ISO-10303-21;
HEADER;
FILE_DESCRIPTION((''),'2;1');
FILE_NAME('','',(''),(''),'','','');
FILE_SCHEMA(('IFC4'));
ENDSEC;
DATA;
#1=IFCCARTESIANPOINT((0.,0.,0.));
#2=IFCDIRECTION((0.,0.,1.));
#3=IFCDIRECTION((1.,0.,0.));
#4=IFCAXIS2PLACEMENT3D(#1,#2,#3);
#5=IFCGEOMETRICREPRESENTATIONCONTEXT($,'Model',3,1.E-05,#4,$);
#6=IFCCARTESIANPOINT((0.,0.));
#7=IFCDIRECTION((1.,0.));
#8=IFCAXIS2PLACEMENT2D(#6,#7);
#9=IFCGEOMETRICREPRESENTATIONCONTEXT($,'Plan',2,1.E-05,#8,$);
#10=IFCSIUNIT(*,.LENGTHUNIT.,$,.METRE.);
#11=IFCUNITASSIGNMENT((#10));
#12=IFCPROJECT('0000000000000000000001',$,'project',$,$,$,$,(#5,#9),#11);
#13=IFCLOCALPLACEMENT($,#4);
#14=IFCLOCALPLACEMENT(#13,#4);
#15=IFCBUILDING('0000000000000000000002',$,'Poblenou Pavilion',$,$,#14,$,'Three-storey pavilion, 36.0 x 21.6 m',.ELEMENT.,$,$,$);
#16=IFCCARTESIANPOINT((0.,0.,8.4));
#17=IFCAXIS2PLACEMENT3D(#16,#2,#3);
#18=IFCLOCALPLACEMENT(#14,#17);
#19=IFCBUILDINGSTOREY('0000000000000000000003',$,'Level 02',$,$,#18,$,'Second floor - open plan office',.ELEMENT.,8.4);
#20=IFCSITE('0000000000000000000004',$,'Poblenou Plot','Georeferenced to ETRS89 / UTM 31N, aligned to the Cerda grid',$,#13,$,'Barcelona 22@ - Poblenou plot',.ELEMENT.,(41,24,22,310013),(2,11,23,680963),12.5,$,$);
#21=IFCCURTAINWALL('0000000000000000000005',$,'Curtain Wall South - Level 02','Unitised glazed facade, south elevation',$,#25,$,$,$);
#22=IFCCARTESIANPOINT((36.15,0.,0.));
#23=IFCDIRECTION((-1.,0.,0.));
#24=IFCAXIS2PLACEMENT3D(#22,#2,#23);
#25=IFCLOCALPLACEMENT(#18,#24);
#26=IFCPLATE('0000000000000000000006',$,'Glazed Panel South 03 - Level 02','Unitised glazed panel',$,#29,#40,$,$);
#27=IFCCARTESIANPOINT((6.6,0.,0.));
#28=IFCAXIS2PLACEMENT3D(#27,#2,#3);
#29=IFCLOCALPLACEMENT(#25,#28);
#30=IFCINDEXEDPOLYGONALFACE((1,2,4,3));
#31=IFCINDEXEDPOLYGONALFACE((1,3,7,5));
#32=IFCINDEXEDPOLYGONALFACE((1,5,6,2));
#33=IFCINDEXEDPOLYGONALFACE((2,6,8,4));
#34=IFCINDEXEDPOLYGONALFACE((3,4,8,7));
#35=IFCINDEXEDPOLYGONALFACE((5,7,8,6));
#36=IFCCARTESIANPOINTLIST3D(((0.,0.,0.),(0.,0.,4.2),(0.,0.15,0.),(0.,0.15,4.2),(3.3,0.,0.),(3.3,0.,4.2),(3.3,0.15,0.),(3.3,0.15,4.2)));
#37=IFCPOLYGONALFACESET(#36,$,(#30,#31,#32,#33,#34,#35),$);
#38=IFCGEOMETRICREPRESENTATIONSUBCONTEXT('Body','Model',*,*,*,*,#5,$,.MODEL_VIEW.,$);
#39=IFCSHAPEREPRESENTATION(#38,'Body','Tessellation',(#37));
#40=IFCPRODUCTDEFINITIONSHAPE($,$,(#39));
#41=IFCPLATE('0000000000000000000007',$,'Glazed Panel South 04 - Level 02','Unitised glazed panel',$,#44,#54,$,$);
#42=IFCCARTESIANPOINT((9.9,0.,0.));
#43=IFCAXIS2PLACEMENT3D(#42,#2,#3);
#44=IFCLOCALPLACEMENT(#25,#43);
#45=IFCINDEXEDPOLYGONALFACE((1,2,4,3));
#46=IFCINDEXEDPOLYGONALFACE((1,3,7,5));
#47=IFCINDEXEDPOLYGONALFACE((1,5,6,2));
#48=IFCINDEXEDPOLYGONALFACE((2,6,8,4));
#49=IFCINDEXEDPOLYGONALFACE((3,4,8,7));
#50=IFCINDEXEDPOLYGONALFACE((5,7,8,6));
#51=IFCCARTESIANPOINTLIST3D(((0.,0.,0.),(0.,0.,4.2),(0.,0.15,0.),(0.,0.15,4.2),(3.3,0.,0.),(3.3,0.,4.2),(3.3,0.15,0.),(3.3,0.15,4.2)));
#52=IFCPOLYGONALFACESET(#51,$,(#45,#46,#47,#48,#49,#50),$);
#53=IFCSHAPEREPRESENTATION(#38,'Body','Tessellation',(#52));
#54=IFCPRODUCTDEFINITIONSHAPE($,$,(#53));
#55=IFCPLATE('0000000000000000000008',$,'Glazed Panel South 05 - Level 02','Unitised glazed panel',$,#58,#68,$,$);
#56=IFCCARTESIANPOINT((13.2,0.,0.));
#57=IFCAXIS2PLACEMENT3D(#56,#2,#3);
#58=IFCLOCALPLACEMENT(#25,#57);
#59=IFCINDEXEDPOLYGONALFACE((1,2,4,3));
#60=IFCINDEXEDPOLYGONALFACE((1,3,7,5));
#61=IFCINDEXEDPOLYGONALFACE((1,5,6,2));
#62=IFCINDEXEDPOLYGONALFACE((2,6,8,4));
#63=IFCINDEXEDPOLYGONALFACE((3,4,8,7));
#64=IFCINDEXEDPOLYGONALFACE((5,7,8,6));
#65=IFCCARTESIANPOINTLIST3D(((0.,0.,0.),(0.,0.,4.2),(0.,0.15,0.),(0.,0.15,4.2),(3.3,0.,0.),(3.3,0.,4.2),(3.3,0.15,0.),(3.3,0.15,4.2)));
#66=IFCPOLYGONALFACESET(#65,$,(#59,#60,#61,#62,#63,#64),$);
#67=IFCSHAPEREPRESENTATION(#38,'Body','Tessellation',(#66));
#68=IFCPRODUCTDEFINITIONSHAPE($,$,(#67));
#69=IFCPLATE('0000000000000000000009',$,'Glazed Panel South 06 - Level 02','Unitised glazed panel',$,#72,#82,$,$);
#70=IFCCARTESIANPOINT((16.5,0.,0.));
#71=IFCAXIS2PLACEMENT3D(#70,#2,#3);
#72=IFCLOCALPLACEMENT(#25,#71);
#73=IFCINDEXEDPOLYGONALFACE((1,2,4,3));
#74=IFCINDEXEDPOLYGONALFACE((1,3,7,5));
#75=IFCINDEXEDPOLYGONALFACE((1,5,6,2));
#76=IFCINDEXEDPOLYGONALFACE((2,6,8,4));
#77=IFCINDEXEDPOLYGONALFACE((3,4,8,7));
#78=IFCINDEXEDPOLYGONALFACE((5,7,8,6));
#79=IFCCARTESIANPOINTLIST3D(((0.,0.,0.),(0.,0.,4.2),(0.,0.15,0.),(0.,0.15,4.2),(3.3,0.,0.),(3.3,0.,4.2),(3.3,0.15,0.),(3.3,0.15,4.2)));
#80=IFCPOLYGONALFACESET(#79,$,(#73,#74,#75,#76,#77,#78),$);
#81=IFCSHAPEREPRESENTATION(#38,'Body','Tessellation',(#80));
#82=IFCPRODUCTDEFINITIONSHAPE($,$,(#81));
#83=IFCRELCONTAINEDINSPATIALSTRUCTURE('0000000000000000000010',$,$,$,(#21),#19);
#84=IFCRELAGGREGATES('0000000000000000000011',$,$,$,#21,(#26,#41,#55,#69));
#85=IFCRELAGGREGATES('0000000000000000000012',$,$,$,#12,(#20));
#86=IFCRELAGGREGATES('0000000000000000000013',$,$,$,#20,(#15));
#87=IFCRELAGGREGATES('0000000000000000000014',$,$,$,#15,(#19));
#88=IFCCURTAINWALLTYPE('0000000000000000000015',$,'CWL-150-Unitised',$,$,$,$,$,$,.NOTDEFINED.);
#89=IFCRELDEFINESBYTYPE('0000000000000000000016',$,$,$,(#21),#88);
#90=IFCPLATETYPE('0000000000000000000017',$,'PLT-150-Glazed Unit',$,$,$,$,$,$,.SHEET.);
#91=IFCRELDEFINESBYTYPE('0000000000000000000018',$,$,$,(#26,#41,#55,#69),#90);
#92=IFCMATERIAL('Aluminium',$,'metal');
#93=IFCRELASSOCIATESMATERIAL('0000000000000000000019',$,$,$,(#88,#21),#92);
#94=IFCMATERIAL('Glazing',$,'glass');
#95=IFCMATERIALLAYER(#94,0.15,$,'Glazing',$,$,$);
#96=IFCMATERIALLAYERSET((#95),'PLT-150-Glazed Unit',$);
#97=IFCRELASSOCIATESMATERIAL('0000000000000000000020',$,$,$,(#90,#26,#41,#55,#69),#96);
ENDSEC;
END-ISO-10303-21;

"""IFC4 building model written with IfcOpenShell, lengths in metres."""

from ifc_helpers import new_model, si_unit, frame, origin_with_axes, origin_2d_with_axis, place, context, subcontext, project, spatial, line, indexed_curve, outline, extrude, material, layer, layer_set, layer_usage, type_object, element, aggregate, save


model = new_model("IFC4")

# Units and contexts
model_context = context("Model", 3, precision=1e-05, world=origin_with_axes())
plan_context = context("Plan", 2, precision=1e-05, world=origin_2d_with_axis())
body_context = subcontext(model_context, "Body", "Model", "MODEL_VIEW")
ifc_project = project(units=[si_unit("LENGTHUNIT", "METRE")], contexts=[model_context, plan_context])

# Site, building, storey
site_placement = place(None, origin_with_axes())
site = spatial("IfcSite", under=ifc_project, at=site_placement, Name="Poblenou Plot", Description="Georeferenced to ETRS89 / UTM 31N, aligned to the Cerda grid", LongName="Barcelona 22@ - Poblenou plot", CompositionType="ELEMENT", RefLatitude=(41, 24, 22, 310013), RefLongitude=(2, 11, 23, 680963), RefElevation=12.5)
building_placement = place(site_placement, origin_with_axes())
building = spatial("IfcBuilding", under=site, at=building_placement, Name="Poblenou Pavilion", LongName="Three-storey pavilion, 36.0 x 21.6 m", CompositionType="ELEMENT")
storey_placement = place(building_placement, frame((0.0, 0.0, 8.4), z_axis=(0.0, 0.0, 1.0), x_axis=(1.0, 0.0, 0.0)))
storey = spatial("IfcBuildingStorey", under=building, at=storey_placement, Name="Level 02", LongName="Second floor - open plan office", CompositionType="ELEMENT", Elevation=8.4)

# Curtain wall, plates
ifc_material_1 = material(Name="Aluminium", Category="metal")
curtain_wall_type = type_object("IfcCurtainWallType", Name="CWL-150-Unitised", PredefinedType="NOTDEFINED", material=ifc_material_1)
curtain_wall_1_placement = place(storey_placement, frame((36.15, 0.0, 0.0), z_axis=(0.0, 0.0, 1.0), x_axis=(-1.0, 0.0, 0.0)))
curtain_wall_1 = element("IfcCurtainWall", 1, at=curtain_wall_1_placement, inside=storey, type_object=curtain_wall_type, material=ifc_material_1, Name="Curtain Wall South - Level 02", Description="Unitised glazed facade, south elevation")
ifc_material_2 = material(Name="Glazing", Category="glass")
ifc_layer_1 = layer(ifc_material_2, 0.15, Name="Glazing")
ifc_layer_set_1 = layer_set([ifc_layer_1], Name="PLT-150-Glazed Unit")
plate_type = type_object("IfcPlateType", Name="PLT-150-Glazed Unit", PredefinedType="SHEET", material=ifc_layer_set_1)
ifc_layer_usage_1 = layer_usage(ifc_layer_set_1, "AXIS2", "POSITIVE", 0.0)
plate_1_placement = place(curtain_wall_1_placement, frame((6.6, 0.0, 0.0), z_axis=(0.0, 0.0, 1.0), x_axis=(1.0, 0.0, 0.0)))
plate_1 = element("IfcPlate", 2, at=plate_1_placement, type_object=plate_type, material=ifc_layer_usage_1, Name="Glazed Panel South 03 - Level 02", Description="Unitised glazed panel", context=body_context, shape_type="SweptSolid", body=[
    extrude(outline(indexed_curve([(0.0, 0.0), (3.3, 0.0), (3.3, 0.15), (0.0, 0.15)], segments=[line(1, 2, 3, 4, 1)])), origin_with_axes(), (0.0, 0.0, 1.0), 4.2),
])
ifc_layer_usage_2 = layer_usage(ifc_layer_set_1, "AXIS2", "POSITIVE", 0.0)
plate_2_placement = place(curtain_wall_1_placement, frame((9.9, 0.0, 0.0), z_axis=(0.0, 0.0, 1.0), x_axis=(1.0, 0.0, 0.0)))
plate_2 = element("IfcPlate", 3, at=plate_2_placement, type_object=plate_type, material=ifc_layer_usage_2, Name="Glazed Panel South 04 - Level 02", Description="Unitised glazed panel", context=body_context, shape_type="SweptSolid", body=[
    extrude(outline(indexed_curve([(0.0, 0.0), (3.3, 0.0), (3.3, 0.15), (0.0, 0.15)], segments=[line(1, 2, 3, 4, 1)])), origin_with_axes(), (0.0, 0.0, 1.0), 4.2),
])
ifc_layer_usage_3 = layer_usage(ifc_layer_set_1, "AXIS2", "POSITIVE", 0.0)
plate_3_placement = place(curtain_wall_1_placement, frame((13.2, 0.0, 0.0), z_axis=(0.0, 0.0, 1.0), x_axis=(1.0, 0.0, 0.0)))
plate_3 = element("IfcPlate", 4, at=plate_3_placement, type_object=plate_type, material=ifc_layer_usage_3, Name="Glazed Panel South 05 - Level 02", Description="Unitised glazed panel", context=body_context, shape_type="SweptSolid", body=[
    extrude(outline(indexed_curve([(0.0, 0.0), (3.3, 0.0), (3.3, 0.15), (0.0, 0.15)], segments=[line(1, 2, 3, 4, 1)])), origin_with_axes(), (0.0, 0.0, 1.0), 4.2),
])
ifc_layer_usage_4 = layer_usage(ifc_layer_set_1, "AXIS2", "POSITIVE", 0.0)
plate_4_placement = place(curtain_wall_1_placement, frame((16.5, 0.0, 0.0), z_axis=(0.0, 0.0, 1.0), x_axis=(1.0, 0.0, 0.0)))
plate_4 = element("IfcPlate", 5, at=plate_4_placement, type_object=plate_type, material=ifc_layer_usage_4, Name="Glazed Panel South 06 - Level 02", Description="Unitised glazed panel", context=body_context, shape_type="SweptSolid", body=[
    extrude(outline(indexed_curve([(0.0, 0.0), (3.3, 0.0), (3.3, 0.15), (0.0, 0.15)], segments=[line(1, 2, 3, 4, 1)])), origin_with_axes(), (0.0, 0.0, 1.0), 4.2),
])
aggregate(curtain_wall_1, [plate_1, plate_2, plate_3, plate_4])

save(model, "model.ifc")
